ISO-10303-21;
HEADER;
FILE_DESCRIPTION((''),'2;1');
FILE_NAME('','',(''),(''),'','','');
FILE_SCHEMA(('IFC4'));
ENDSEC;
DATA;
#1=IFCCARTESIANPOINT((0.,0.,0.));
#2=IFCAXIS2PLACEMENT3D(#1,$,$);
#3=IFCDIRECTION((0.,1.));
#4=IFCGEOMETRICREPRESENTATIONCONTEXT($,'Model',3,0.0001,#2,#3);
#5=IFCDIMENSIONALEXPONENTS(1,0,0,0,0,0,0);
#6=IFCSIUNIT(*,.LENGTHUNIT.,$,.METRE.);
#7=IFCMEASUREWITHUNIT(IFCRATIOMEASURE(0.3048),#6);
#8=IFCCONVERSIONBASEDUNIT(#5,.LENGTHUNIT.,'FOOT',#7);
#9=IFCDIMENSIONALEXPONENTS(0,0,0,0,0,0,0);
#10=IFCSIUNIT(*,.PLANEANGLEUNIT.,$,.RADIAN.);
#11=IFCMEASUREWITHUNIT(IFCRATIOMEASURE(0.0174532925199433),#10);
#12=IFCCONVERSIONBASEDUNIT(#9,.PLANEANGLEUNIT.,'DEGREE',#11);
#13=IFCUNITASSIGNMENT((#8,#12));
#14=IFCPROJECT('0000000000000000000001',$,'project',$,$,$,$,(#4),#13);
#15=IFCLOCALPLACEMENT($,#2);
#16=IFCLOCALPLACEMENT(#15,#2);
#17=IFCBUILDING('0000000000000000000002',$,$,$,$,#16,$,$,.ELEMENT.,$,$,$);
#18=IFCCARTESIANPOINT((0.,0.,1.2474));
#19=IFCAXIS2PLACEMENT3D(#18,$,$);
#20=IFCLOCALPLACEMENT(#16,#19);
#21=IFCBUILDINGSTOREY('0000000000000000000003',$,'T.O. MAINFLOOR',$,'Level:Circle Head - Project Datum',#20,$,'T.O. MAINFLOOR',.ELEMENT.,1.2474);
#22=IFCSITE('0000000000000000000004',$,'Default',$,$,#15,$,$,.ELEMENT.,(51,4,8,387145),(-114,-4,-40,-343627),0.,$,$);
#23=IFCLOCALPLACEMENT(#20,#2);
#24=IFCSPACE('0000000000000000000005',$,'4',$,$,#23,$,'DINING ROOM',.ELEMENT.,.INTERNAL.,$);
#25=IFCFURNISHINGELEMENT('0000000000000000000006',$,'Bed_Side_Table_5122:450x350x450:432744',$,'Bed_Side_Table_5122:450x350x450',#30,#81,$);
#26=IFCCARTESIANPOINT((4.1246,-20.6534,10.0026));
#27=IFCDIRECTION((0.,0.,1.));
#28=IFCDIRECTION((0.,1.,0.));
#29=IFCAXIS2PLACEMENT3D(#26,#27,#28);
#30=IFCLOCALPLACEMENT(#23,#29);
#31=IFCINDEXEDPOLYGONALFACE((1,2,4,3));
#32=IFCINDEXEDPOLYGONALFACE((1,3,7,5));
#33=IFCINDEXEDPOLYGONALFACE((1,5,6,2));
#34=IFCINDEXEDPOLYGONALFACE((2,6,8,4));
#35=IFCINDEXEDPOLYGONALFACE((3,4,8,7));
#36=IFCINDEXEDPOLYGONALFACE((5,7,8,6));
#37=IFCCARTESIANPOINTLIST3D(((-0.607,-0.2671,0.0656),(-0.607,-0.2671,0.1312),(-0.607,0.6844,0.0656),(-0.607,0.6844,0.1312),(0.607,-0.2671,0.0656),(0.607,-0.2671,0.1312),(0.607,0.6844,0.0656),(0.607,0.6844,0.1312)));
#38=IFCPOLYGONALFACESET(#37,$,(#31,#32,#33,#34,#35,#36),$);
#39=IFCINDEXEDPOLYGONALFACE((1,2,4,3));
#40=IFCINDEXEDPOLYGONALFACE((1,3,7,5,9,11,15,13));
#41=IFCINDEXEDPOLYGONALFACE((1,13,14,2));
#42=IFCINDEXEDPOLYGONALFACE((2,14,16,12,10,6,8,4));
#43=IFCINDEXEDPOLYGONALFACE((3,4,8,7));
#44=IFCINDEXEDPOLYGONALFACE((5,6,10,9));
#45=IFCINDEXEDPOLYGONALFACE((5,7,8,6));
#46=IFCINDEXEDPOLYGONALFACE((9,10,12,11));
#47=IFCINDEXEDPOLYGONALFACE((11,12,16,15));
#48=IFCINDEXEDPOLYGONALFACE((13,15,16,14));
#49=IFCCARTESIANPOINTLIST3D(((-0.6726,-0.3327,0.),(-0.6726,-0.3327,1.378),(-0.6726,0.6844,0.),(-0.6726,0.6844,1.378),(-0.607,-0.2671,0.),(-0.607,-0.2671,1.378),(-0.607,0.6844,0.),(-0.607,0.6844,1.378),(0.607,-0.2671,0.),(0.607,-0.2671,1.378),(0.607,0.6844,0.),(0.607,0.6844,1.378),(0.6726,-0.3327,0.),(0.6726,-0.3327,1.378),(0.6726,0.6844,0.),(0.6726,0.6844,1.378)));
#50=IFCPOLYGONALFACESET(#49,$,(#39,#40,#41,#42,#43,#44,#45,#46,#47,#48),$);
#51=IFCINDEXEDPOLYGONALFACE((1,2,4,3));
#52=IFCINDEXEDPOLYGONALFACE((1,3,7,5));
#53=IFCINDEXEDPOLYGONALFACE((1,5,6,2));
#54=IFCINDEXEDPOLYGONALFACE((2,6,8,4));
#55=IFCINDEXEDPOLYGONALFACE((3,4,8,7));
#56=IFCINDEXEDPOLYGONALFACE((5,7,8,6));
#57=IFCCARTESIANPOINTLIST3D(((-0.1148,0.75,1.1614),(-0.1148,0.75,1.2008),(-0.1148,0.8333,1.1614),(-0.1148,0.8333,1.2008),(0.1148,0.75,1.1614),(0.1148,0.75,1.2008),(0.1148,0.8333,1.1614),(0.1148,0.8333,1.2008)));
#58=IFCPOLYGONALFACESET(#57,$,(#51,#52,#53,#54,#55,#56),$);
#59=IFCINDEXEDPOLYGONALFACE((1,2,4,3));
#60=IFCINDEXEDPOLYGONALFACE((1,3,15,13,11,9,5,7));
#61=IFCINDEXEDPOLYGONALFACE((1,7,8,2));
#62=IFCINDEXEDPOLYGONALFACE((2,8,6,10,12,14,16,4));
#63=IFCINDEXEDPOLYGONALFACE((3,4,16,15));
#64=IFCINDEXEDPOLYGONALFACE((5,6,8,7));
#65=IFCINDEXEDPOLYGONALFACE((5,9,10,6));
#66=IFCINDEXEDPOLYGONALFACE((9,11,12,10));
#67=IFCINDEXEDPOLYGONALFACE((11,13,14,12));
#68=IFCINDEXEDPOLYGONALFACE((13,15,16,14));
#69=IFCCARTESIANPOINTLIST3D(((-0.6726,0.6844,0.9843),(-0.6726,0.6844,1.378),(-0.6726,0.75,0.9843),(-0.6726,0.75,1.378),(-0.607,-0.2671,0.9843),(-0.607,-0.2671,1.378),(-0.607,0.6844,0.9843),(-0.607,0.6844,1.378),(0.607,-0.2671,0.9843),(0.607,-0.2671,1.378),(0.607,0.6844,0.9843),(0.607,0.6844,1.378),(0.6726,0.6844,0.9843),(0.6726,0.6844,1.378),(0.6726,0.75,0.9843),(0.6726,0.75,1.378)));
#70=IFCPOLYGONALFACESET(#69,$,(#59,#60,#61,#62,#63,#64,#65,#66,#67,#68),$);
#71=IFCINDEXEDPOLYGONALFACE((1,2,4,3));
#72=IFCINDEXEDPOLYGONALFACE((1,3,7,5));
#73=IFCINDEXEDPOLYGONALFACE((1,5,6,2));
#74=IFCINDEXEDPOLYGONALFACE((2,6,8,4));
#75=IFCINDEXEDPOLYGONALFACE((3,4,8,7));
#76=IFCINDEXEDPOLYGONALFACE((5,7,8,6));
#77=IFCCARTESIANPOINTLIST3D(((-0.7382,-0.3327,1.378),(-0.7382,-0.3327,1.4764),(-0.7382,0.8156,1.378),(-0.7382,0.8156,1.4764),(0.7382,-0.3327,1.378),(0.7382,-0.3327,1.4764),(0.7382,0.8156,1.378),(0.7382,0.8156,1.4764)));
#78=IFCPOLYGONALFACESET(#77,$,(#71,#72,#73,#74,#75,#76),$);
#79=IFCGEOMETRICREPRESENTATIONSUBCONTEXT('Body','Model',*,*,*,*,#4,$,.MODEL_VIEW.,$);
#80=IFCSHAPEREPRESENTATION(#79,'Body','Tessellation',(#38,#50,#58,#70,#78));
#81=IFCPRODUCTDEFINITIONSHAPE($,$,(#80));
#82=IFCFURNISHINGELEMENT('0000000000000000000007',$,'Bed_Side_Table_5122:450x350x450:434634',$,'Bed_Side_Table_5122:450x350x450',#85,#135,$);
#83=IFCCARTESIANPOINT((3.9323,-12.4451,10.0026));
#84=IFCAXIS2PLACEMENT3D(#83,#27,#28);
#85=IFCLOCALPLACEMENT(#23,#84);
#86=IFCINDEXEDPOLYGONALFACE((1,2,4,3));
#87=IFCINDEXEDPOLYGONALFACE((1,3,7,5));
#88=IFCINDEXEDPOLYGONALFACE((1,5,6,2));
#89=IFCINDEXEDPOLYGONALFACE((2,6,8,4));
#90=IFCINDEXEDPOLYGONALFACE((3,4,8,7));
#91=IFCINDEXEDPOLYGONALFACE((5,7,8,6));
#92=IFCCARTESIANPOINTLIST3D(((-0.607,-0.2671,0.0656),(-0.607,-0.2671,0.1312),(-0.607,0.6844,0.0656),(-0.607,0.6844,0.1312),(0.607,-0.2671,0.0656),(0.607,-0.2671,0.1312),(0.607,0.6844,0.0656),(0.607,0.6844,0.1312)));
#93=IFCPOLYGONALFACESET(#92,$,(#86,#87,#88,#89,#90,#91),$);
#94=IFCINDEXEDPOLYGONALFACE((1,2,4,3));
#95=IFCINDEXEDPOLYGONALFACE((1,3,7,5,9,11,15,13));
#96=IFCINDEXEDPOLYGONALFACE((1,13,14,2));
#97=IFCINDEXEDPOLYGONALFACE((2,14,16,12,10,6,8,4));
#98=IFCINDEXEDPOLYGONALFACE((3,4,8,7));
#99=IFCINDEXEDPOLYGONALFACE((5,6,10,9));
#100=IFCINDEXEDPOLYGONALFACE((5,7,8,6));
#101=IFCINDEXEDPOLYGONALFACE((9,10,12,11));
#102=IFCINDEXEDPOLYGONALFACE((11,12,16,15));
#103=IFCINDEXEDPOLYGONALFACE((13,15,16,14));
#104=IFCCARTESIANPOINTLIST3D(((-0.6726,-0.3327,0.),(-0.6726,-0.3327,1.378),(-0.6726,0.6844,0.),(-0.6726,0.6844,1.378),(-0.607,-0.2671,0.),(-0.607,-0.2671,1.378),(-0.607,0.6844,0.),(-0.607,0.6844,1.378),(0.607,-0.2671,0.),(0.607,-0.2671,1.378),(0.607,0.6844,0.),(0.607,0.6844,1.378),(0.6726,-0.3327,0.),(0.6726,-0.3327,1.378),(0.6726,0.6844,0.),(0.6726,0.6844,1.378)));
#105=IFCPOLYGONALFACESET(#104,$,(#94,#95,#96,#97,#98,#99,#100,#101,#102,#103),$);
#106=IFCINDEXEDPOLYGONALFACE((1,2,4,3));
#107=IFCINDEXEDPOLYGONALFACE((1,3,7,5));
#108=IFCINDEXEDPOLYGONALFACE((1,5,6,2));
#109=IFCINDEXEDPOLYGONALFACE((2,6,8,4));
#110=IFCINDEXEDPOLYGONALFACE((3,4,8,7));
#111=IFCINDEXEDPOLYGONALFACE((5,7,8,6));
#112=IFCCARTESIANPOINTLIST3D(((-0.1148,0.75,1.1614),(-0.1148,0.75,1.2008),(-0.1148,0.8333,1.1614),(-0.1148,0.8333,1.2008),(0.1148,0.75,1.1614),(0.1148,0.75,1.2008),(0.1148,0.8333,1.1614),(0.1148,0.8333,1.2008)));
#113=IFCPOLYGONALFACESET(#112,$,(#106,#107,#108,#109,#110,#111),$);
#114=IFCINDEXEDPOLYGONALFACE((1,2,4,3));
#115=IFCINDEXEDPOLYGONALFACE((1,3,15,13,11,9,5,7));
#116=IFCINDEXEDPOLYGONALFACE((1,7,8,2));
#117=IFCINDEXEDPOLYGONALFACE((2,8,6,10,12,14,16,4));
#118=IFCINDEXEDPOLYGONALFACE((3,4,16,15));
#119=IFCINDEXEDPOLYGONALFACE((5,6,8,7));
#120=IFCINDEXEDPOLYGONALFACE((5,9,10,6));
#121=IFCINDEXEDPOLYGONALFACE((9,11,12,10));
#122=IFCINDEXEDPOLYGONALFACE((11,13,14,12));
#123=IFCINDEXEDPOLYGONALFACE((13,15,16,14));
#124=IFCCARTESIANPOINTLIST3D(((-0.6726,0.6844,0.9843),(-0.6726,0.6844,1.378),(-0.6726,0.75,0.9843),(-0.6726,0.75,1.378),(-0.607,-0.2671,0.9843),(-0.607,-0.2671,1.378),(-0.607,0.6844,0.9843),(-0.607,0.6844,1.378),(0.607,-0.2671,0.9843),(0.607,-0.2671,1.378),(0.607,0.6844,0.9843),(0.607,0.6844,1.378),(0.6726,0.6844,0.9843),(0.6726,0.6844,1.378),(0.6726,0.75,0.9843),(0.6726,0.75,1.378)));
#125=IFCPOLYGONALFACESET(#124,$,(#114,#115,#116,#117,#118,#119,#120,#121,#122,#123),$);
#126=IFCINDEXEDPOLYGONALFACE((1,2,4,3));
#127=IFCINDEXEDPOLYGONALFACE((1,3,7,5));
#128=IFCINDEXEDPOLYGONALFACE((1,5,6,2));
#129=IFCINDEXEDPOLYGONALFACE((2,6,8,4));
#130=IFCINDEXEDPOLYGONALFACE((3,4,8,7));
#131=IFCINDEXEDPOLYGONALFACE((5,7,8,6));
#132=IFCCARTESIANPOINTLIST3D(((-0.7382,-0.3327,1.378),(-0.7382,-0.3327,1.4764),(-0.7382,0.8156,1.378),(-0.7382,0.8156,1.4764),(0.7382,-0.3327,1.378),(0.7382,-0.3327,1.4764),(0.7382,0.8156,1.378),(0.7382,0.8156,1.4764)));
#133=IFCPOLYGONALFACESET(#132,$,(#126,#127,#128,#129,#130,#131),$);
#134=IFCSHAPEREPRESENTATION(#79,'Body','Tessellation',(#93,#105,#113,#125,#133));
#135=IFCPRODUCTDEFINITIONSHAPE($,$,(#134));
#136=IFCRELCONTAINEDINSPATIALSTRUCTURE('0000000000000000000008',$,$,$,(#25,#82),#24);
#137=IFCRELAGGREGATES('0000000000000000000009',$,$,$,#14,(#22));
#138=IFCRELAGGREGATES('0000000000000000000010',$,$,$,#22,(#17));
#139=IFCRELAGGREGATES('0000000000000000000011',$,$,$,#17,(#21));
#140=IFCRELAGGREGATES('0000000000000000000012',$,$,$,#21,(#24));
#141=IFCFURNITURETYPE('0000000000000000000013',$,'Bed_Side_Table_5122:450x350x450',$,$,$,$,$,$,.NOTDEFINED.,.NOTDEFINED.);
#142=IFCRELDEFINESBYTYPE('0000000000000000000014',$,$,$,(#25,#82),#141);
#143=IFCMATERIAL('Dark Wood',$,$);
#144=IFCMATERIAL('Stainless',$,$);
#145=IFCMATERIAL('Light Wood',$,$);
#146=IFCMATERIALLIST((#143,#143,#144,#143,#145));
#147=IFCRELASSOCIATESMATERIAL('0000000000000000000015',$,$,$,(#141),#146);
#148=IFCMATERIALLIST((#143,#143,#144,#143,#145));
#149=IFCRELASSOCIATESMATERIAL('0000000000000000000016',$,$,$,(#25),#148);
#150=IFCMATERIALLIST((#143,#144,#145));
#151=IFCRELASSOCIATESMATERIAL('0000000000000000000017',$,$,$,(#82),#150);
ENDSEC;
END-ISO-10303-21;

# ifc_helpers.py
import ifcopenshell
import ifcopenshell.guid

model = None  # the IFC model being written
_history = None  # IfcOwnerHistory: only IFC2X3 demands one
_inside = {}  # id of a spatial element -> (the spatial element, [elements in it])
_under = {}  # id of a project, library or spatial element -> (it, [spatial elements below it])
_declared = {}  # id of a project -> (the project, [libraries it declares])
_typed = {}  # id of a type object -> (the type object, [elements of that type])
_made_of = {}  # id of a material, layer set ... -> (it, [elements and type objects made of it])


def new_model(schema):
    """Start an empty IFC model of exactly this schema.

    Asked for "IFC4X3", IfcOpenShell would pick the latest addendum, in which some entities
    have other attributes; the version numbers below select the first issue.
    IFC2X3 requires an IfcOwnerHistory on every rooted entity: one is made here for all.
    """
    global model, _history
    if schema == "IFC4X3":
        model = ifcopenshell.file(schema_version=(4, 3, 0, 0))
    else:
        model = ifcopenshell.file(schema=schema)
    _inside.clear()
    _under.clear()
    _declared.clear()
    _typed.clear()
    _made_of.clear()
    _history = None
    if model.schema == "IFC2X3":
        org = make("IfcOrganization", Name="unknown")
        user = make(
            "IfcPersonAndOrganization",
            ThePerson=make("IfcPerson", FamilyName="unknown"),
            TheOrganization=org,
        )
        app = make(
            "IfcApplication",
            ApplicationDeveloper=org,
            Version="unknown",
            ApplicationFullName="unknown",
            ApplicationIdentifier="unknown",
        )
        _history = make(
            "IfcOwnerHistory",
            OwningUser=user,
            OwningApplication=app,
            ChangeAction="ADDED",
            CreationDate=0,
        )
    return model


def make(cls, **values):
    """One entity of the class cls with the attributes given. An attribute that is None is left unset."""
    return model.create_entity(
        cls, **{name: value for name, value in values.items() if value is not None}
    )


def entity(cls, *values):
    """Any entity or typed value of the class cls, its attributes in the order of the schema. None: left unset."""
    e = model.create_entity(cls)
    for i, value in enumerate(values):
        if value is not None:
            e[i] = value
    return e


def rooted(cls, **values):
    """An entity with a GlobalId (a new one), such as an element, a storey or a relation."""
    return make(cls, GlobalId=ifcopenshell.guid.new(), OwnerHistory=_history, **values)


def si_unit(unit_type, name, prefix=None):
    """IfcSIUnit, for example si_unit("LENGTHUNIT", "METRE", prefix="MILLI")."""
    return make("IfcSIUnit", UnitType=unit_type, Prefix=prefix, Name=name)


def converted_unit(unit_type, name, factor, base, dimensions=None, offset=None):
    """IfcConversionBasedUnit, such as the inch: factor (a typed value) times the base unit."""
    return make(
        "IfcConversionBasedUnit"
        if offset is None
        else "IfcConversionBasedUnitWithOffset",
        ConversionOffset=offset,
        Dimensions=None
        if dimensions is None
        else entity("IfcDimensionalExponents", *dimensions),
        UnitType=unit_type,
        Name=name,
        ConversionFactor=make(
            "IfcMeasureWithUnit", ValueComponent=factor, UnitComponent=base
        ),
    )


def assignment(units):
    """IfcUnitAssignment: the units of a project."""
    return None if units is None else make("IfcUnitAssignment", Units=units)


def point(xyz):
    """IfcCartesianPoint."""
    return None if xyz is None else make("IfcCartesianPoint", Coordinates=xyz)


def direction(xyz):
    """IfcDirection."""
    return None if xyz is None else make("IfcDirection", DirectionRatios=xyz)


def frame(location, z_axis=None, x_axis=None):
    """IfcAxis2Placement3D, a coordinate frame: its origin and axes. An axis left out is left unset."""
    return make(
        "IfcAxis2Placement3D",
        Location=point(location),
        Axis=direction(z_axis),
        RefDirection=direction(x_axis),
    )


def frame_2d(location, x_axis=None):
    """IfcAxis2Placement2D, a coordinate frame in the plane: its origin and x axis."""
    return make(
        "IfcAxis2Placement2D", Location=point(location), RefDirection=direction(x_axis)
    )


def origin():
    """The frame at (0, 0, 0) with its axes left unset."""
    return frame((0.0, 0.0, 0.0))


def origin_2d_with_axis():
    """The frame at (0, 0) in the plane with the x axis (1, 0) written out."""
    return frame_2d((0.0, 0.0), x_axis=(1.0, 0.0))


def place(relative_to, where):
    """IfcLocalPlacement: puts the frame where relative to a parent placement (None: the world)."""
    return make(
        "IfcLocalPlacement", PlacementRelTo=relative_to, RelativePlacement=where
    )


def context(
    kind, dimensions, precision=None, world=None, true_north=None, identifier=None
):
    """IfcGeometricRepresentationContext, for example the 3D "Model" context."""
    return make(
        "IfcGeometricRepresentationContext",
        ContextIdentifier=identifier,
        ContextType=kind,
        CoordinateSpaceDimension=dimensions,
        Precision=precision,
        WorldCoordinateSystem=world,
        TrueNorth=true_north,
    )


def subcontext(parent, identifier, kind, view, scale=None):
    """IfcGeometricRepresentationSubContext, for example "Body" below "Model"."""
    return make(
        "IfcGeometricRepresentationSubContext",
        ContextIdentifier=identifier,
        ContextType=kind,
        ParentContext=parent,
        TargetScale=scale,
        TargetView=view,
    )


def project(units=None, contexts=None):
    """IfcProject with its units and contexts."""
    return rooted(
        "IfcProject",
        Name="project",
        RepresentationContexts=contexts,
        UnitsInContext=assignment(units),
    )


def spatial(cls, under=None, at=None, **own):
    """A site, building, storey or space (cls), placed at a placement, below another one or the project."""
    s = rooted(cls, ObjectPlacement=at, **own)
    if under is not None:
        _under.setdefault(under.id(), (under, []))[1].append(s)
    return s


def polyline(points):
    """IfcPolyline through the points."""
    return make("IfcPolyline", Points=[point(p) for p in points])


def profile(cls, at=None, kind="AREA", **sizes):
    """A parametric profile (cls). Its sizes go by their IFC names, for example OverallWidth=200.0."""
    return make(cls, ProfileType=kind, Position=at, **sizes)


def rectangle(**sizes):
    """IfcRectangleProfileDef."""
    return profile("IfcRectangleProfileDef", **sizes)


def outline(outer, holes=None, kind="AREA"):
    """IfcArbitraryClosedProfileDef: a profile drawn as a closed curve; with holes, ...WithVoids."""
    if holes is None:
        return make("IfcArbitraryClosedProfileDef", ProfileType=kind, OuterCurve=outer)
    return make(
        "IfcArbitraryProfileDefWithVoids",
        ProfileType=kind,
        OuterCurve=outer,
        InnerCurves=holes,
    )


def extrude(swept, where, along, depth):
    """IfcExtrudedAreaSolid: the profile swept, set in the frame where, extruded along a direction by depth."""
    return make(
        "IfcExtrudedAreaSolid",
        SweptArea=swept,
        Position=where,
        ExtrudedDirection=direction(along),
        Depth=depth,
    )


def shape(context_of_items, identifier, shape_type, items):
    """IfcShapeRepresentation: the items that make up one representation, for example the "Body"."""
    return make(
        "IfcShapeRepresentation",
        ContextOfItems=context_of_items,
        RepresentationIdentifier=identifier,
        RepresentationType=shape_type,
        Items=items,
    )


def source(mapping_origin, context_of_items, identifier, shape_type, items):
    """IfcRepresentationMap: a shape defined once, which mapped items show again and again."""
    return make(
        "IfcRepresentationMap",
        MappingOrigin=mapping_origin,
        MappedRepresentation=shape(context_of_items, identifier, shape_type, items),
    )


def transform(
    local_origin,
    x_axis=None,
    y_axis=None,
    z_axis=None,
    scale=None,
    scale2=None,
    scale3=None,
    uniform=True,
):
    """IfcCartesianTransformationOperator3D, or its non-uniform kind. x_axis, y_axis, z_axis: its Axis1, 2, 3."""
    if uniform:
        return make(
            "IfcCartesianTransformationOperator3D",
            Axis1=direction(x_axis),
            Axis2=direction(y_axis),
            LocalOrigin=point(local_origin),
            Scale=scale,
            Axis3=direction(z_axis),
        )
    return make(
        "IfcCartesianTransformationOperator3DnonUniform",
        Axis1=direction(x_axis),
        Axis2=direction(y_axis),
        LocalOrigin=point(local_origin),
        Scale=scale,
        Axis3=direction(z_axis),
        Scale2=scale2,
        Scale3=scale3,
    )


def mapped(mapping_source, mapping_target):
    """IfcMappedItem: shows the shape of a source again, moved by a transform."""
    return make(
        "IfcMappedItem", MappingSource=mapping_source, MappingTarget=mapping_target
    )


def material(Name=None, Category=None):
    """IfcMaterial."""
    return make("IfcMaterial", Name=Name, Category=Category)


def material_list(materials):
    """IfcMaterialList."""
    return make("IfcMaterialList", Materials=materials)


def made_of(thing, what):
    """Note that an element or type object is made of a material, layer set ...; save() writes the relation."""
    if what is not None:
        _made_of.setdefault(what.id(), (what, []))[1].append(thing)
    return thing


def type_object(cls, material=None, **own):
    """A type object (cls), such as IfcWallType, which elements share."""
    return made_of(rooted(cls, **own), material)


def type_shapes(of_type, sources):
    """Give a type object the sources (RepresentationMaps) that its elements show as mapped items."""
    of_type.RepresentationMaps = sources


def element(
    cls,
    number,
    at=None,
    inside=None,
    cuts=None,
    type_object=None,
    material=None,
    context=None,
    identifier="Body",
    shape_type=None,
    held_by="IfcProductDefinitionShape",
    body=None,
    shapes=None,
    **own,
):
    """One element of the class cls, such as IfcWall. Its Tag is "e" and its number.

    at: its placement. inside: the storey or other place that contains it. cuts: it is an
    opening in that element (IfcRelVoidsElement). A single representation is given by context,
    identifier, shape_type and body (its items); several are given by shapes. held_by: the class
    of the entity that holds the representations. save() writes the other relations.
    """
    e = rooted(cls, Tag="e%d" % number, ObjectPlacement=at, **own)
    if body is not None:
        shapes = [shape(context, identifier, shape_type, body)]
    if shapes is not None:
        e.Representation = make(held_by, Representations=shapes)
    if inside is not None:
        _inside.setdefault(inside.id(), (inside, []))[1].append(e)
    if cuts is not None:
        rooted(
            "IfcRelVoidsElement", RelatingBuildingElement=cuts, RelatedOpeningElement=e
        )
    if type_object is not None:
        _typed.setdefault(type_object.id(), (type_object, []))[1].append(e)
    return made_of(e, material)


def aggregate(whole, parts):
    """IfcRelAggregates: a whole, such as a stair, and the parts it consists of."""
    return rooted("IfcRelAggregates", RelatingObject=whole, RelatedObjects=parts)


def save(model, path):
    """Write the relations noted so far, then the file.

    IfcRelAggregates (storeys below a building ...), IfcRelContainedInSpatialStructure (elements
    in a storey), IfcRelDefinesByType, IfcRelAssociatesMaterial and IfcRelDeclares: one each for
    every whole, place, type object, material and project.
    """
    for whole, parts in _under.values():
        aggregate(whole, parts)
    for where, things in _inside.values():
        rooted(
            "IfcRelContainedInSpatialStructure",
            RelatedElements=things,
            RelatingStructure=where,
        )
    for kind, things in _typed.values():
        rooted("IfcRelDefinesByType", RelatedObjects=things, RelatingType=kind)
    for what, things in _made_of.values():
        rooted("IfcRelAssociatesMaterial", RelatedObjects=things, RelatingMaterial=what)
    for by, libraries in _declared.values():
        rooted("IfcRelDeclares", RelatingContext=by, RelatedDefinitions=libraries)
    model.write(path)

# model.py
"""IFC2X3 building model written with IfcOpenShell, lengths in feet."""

from ifc_helpers import new_model, entity, si_unit, converted_unit, direction, frame, frame_2d, origin, origin_2d_with_axis, place, context, subcontext, project, spatial, polyline, rectangle, outline, extrude, source, transform, mapped, material, material_list, type_object, type_shapes, element, save


model = new_model("IFC2X3")

# Units and contexts
model_context = context("Model", 3, precision=0.0001, world=origin(), true_north=direction((0.0, 1.0)))
body_context = subcontext(model_context, "Body", "Model", "MODEL_VIEW")
ifc_project = project(units=[converted_unit("LENGTHUNIT", "FOOT", entity("IfcRatioMeasure", 0.3048), si_unit("LENGTHUNIT", "METRE"), dimensions=[1, 0, 0, 0, 0, 0, 0]), converted_unit("PLANEANGLEUNIT", "DEGREE", entity("IfcRatioMeasure", 0.0174532925199433), si_unit("PLANEANGLEUNIT", "RADIAN"), dimensions=[0, 0, 0, 0, 0, 0, 0])], contexts=[model_context])

# Site, building, storey
site_placement = place(None, origin())
site = spatial("IfcSite", under=ifc_project, at=site_placement, Name="Default", CompositionType="ELEMENT", RefLatitude=(51, 4, 8, 387145), RefLongitude=(-114, -4, -40, -343627), RefElevation=0.0)
building_placement = place(site_placement, origin())
building = spatial("IfcBuilding", under=site, at=building_placement, CompositionType="ELEMENT")
storey_placement = place(building_placement, frame((0.0, 0.0, 1.2474)))
storey = spatial("IfcBuildingStorey", under=building, at=storey_placement, Name="T.O. MAINFLOOR", ObjectType="Level:Circle Head - Project Datum", LongName="T.O. MAINFLOOR", CompositionType="ELEMENT", Elevation=1.2474)

# Shared definitions
space_placement = place(storey_placement, origin())
space = spatial("IfcSpace", under=storey, at=space_placement, Name="4", LongName="DINING ROOM", CompositionType="ELEMENT", InteriorOrExteriorSpace="INTERNAL")

# Furnishing elements
ifc_material_1 = material(Name="Dark Wood")
ifc_material_2 = material(Name="Stainless")
ifc_material_3 = material(Name="Light Wood")
ifc_material_list_1 = material_list([ifc_material_1, ifc_material_1, ifc_material_2, ifc_material_1, ifc_material_3])
ifc_material_list_2 = material_list([ifc_material_1, ifc_material_1, ifc_material_2, ifc_material_1, ifc_material_3])
furniture_type_1 = type_object("IfcFurnitureType", Name="Bed_Side_Table_5122:450x350x450", material=ifc_material_list_2)
shared_shape_1 = source(origin(), body_context, "Body", "SweptSolid", [
    extrude(rectangle(XDim=1.2139, YDim=0.9514, at=origin_2d_with_axis()), frame((0.0, 0.2087, 0.0656), z_axis=(0.0, 0.0, 1.0), x_axis=(-1.0, 0.0, 0.0)), (0.0, 0.0, 1.0), 0.0656),
    extrude(outline(polyline([(-0.4921, -0.6726), (0.5249, -0.6726), (0.5249, 0.6726), (-0.4921, 0.6726), (-0.4921, 0.607), (0.4593, 0.607), (0.4593, -0.607), (-0.4921, -0.607), (-0.4921, -0.6726)])), frame((0.0, 0.1923, 0.0), z_axis=(0.0, 0.0, 1.0), x_axis=(0.0, -1.0, 0.0)), (0.0, 0.0, 1.0), 1.378),
    extrude(rectangle(XDim=0.2297, YDim=0.0833, at=frame_2d((0.0, 0.0), x_axis=(1.0, 0.0))), frame((0.0, 0.7917, 1.1614), z_axis=(0.0, 0.0, 1.0), x_axis=(-1.0, 0.0, 0.0)), (0.0, 0.0, 1.0), 0.0394),
    extrude(outline(polyline([(-0.6726, -0.2215), (-0.6726, -0.2871), (0.6726, -0.2871), (0.6726, -0.2215), (0.607, -0.2215), (0.607, 0.73), (-0.607, 0.73), (-0.607, -0.2215), (-0.6726, -0.2215)])), frame((0.0, 0.4629, 0.9843), z_axis=(0.0, 0.0, -1.0), x_axis=(1.0, 0.0, 0.0)), (0.0, 0.0, -1.0), 0.3937),
    extrude(rectangle(XDim=1.4764, YDim=1.1483, at=origin_2d_with_axis()), frame((0.0, 0.2415, 1.378)), (0.0, 0.0, 1.0), 0.0984),
])
type_shapes(furniture_type_1, [shared_shape_1])
furnishing_1_placement = place(space_placement, frame((4.1246, -20.6534, 10.0026), z_axis=(0.0, 0.0, 1.0), x_axis=(0.0, 1.0, 0.0)))
element("IfcFurnishingElement", 1, at=furnishing_1_placement, inside=space, type_object=furniture_type_1, material=ifc_material_list_1, Name="Bed_Side_Table_5122:450x350x450:432744", ObjectType="Bed_Side_Table_5122:450x350x450", context=body_context, shape_type="MappedRepresentation", body=[
    mapped(shared_shape_1, transform((0.0, 0.0, 0.0), scale=1.0)),
])
ifc_material_list_3 = material_list([ifc_material_1, ifc_material_2, ifc_material_3])
furnishing_2_placement = place(space_placement, frame((3.9323, -12.4451, 10.0026), z_axis=(0.0, 0.0, 1.0), x_axis=(0.0, 1.0, 0.0)))
element("IfcFurnishingElement", 2, at=furnishing_2_placement, inside=space, type_object=furniture_type_1, material=ifc_material_list_3, Name="Bed_Side_Table_5122:450x350x450:434634", ObjectType="Bed_Side_Table_5122:450x350x450", context=body_context, shape_type="MappedRepresentation", body=[
    mapped(shared_shape_1, transform((0.0, 0.0, 0.0), scale=1.0)),
])

save(model, "model.ifc")
